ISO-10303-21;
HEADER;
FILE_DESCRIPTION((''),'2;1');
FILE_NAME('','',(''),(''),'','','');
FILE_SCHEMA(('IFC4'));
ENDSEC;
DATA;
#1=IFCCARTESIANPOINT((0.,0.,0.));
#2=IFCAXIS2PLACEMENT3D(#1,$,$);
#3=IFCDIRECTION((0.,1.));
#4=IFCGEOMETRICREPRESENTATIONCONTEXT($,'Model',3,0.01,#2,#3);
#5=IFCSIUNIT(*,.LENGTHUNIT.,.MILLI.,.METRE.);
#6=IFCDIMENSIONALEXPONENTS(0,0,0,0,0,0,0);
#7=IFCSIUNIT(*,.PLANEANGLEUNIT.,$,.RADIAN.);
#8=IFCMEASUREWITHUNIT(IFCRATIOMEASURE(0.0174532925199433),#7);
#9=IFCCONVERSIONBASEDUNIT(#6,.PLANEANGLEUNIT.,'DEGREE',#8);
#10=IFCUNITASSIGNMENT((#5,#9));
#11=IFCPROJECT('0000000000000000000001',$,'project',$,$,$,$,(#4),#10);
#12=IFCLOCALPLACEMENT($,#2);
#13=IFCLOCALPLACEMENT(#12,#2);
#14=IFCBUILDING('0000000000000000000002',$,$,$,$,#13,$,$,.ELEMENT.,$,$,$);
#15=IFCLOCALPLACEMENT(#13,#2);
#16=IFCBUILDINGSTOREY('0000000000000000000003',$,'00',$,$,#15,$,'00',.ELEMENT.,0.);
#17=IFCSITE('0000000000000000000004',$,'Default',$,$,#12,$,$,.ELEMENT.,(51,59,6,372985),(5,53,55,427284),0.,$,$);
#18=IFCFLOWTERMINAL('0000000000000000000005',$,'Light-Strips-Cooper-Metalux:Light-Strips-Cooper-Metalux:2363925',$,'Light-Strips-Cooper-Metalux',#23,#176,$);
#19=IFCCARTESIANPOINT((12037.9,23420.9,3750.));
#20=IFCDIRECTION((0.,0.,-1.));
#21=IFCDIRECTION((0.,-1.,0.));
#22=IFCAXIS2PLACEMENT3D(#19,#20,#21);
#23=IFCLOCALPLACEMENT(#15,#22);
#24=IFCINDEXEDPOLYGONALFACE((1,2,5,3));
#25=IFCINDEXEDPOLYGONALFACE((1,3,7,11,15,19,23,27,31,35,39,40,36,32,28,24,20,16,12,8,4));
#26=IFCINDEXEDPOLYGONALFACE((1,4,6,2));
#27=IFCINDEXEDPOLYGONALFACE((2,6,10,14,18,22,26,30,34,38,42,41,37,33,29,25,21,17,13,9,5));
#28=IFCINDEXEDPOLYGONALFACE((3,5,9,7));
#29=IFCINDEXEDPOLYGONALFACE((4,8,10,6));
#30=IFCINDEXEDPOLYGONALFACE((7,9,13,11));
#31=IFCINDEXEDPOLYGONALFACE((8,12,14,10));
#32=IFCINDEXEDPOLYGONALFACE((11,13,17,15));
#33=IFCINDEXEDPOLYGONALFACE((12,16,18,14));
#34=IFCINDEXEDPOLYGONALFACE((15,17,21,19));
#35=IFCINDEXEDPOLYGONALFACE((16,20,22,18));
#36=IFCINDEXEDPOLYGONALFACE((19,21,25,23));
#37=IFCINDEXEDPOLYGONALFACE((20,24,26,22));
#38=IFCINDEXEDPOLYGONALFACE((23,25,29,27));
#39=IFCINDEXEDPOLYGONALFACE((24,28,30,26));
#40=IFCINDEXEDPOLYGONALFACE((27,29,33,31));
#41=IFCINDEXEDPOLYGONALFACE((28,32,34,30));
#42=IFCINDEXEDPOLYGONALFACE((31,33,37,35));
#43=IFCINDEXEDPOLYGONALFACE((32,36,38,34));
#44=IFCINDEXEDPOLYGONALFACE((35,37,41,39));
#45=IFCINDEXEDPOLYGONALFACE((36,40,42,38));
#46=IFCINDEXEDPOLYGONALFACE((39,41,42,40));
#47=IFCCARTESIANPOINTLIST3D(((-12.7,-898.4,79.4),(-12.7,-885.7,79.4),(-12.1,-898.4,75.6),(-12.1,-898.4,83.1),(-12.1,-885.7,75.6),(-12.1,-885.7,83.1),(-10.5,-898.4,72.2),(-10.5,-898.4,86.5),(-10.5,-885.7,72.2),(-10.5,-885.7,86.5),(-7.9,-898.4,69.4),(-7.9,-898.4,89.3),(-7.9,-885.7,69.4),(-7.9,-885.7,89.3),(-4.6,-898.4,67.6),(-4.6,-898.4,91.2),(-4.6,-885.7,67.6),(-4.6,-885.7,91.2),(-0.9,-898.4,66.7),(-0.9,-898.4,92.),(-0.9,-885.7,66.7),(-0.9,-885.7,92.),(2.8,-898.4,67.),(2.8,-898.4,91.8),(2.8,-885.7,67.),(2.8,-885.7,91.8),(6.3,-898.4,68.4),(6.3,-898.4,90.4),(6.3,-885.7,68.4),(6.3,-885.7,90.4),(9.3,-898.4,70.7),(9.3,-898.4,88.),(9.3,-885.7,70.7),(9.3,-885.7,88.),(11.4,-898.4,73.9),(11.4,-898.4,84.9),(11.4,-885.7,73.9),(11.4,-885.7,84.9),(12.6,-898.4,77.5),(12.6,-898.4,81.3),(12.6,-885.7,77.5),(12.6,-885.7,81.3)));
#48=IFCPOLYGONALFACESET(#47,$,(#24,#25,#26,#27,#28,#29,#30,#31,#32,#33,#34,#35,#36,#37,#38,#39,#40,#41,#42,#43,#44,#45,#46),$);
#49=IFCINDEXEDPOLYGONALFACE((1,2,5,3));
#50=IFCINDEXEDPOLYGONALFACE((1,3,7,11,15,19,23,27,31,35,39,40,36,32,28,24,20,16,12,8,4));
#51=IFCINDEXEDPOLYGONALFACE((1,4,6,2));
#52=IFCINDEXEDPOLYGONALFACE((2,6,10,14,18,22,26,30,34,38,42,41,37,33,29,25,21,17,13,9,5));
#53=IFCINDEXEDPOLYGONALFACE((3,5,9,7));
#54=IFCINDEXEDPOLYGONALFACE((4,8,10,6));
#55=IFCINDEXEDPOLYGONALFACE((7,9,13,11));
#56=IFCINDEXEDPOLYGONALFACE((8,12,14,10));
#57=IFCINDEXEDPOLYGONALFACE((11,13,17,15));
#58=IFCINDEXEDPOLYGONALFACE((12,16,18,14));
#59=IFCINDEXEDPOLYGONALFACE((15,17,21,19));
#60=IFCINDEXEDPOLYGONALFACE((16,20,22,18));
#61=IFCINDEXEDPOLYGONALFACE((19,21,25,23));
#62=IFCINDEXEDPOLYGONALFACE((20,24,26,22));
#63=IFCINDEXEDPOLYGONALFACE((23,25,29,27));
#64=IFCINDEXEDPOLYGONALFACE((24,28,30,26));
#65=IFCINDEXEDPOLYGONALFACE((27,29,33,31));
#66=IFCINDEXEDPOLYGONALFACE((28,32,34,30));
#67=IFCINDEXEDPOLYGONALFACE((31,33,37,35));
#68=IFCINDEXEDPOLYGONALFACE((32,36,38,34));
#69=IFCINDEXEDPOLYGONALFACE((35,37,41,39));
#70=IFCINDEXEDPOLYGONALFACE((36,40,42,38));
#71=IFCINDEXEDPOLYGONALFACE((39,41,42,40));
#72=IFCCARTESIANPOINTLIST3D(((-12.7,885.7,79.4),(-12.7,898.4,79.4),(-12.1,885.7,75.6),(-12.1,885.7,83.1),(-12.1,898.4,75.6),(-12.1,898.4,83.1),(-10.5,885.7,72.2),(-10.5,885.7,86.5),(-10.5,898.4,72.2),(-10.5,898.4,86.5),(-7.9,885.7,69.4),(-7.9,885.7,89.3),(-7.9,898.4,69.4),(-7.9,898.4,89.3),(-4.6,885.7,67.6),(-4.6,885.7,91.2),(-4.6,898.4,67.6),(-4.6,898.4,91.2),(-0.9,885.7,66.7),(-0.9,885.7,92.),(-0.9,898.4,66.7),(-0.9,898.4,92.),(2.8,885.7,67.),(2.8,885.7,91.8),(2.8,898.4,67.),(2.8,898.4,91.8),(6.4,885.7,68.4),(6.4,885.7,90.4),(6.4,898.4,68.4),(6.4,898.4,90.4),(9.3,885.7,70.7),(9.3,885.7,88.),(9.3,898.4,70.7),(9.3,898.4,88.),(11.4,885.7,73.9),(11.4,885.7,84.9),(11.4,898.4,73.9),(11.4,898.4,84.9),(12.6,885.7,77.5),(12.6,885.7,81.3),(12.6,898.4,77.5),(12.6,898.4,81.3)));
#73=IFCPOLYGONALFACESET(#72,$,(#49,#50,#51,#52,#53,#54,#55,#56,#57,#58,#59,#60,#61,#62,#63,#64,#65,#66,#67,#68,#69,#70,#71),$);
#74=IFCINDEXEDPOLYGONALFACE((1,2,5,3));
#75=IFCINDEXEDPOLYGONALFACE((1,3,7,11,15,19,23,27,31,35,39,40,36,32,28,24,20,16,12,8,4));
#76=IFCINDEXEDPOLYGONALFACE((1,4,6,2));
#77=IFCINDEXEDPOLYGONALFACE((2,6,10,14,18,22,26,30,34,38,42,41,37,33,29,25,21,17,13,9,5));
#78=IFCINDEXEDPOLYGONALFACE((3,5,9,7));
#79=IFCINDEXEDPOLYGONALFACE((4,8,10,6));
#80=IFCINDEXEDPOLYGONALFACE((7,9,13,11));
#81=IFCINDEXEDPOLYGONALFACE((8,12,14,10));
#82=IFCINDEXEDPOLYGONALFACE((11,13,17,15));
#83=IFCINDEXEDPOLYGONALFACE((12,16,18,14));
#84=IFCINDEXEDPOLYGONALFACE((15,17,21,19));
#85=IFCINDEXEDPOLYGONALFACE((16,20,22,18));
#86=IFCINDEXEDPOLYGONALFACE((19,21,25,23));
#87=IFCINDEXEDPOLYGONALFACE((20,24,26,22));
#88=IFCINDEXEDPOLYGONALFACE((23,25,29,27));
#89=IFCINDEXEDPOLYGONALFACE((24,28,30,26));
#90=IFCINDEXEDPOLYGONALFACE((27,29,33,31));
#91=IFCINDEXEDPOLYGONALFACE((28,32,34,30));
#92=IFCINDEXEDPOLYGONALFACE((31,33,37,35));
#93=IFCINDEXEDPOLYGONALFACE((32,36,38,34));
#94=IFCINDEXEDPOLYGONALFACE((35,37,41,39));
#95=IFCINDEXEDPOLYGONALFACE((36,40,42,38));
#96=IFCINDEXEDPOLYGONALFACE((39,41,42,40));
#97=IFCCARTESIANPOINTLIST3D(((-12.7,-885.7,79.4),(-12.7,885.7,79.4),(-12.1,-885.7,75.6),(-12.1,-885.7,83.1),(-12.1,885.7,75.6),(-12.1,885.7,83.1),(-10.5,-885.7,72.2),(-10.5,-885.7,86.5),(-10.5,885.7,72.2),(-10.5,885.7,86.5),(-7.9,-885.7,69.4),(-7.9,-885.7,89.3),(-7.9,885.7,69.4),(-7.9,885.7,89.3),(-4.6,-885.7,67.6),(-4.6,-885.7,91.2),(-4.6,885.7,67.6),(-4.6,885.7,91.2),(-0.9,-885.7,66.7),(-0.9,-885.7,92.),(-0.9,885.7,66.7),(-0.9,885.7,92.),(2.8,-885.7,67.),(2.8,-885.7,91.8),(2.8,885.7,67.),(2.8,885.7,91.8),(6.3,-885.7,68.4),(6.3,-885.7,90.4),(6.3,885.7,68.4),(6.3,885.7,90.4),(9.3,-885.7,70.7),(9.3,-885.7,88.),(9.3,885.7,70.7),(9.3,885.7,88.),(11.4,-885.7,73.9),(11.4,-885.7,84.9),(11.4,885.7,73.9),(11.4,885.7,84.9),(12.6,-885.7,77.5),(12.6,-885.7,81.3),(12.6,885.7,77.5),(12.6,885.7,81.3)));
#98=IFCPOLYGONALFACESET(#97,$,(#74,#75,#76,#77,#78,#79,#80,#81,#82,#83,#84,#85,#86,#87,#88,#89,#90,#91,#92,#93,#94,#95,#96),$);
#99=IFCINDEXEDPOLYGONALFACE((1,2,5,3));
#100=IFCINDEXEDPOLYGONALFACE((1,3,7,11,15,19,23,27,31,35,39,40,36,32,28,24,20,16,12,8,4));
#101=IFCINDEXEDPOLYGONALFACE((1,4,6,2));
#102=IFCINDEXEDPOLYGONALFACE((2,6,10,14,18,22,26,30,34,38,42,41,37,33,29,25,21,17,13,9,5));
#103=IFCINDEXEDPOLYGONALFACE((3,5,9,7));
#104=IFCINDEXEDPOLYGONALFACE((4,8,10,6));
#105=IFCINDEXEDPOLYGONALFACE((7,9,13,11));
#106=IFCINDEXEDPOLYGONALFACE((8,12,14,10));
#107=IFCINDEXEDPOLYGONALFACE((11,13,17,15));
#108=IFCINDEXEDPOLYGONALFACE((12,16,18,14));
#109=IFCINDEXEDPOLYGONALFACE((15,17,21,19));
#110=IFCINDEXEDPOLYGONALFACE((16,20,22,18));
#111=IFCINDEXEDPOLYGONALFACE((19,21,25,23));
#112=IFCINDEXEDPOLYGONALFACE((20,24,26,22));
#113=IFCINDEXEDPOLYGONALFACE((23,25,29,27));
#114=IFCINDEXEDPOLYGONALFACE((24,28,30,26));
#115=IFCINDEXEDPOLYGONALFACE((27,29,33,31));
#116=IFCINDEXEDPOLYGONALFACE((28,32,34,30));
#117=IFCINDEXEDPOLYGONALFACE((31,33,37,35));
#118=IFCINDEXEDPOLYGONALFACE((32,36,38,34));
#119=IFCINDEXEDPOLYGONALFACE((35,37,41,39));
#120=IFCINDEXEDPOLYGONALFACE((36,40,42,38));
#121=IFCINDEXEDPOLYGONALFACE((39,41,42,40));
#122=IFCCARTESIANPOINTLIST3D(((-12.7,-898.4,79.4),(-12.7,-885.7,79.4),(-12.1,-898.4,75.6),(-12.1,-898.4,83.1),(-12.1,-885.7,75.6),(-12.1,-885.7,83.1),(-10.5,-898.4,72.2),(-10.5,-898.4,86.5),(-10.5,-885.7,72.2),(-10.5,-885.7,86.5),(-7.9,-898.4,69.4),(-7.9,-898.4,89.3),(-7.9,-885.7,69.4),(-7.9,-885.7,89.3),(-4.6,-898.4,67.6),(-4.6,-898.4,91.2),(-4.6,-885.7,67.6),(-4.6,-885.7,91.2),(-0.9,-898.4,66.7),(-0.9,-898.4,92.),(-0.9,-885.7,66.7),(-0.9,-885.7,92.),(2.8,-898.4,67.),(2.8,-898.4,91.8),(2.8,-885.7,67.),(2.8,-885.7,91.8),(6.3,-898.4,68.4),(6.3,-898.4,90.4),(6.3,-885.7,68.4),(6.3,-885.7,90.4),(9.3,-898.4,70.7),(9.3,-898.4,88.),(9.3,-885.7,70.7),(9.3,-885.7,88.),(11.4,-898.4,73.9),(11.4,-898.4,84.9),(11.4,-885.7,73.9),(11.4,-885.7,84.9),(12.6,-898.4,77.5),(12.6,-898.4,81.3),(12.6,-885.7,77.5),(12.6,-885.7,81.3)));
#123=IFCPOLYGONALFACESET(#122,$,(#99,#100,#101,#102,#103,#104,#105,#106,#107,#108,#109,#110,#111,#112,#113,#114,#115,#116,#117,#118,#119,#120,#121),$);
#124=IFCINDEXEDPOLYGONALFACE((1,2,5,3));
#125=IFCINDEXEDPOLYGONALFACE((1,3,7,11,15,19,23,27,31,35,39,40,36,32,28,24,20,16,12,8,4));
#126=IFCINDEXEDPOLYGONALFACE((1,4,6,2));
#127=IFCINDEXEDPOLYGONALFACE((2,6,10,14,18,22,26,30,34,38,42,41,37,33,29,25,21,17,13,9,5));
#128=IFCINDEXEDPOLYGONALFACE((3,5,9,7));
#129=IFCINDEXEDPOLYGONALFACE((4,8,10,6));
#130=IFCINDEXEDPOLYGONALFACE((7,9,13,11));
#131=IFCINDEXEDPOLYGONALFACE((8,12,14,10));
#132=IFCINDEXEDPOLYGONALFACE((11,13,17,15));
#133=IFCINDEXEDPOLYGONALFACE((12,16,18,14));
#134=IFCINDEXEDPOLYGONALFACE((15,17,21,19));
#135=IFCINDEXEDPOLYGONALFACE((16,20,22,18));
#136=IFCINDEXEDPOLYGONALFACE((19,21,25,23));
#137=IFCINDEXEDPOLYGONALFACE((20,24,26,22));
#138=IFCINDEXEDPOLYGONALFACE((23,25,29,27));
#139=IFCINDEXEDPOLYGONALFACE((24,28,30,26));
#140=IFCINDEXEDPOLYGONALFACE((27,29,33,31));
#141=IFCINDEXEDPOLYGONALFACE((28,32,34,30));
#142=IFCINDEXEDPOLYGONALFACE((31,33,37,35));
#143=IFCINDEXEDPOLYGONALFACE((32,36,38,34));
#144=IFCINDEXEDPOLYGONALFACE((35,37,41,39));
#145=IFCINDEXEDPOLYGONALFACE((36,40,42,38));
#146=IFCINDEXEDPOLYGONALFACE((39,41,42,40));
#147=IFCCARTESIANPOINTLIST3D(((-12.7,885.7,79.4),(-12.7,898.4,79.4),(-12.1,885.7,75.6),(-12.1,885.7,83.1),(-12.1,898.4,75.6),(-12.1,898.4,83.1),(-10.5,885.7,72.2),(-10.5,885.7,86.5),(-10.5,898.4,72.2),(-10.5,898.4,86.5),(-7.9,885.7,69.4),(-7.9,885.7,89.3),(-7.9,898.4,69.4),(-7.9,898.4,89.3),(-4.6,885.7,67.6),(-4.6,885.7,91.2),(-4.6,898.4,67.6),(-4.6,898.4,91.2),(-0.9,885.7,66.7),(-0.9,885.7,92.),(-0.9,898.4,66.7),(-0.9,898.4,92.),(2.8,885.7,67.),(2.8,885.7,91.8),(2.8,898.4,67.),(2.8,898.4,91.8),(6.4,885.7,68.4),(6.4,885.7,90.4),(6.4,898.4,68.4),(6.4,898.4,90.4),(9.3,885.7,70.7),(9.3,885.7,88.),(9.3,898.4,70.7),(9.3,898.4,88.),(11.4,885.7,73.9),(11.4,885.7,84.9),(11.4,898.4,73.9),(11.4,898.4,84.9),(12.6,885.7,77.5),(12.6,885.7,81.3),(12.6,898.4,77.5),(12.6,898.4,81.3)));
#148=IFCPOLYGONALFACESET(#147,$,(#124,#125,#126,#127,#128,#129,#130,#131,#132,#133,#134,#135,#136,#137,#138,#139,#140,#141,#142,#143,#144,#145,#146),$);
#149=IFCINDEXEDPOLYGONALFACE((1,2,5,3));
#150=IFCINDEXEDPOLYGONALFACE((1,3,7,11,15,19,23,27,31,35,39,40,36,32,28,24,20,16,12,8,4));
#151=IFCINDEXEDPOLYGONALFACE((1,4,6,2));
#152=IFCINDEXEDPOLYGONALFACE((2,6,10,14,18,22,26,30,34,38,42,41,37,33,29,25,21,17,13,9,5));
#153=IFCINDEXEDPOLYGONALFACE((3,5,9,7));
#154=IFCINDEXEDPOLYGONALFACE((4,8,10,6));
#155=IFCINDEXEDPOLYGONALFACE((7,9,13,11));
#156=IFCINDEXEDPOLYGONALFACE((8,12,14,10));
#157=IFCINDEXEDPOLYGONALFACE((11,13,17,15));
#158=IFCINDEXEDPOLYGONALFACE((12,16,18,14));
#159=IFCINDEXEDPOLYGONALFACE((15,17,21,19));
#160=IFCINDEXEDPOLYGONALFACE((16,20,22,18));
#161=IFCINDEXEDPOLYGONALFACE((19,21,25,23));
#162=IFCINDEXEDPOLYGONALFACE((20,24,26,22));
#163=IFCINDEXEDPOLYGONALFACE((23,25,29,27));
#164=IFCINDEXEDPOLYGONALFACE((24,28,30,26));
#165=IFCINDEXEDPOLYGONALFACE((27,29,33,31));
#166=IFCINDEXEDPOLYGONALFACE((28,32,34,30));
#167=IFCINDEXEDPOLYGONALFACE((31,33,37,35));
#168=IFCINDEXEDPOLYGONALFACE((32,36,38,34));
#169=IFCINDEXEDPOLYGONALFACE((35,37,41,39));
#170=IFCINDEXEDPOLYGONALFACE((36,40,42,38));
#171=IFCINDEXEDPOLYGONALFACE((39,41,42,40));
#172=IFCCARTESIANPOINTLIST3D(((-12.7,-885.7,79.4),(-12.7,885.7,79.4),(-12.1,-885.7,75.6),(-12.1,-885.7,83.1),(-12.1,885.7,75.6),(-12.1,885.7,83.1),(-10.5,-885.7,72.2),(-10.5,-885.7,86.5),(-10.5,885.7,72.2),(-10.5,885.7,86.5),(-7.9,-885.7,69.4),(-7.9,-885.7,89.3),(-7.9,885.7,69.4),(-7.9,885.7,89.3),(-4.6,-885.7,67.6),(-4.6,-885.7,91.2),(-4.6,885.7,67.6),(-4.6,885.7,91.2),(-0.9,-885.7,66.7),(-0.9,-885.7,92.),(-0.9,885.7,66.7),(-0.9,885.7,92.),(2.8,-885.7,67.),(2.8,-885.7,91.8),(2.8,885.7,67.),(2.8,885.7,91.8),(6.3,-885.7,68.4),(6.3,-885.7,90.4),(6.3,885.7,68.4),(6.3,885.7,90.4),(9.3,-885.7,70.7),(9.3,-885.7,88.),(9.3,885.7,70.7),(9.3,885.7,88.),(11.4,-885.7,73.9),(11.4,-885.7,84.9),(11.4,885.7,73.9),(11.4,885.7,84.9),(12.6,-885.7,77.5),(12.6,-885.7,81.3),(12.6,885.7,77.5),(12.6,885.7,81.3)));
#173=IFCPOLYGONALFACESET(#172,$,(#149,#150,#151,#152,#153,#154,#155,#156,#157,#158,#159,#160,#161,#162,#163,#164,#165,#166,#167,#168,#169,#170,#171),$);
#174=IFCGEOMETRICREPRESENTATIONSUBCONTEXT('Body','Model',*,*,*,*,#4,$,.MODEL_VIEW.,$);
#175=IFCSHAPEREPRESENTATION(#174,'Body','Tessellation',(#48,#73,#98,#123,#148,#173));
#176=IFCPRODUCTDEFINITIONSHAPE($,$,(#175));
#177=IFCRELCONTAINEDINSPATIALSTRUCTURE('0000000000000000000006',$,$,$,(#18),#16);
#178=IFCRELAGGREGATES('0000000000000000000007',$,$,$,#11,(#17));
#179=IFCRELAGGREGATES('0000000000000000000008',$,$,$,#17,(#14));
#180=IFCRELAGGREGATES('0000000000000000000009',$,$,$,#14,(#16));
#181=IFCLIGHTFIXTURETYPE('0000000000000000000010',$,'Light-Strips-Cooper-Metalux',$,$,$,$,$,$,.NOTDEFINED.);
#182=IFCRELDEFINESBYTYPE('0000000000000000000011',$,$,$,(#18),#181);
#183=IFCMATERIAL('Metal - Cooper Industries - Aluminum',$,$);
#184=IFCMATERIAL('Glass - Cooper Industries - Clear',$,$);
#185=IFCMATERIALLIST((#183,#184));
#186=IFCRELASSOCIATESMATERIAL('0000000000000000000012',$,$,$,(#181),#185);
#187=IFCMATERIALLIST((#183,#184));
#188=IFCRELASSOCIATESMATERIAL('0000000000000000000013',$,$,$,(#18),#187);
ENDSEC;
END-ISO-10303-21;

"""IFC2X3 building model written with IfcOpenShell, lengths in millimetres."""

from ifc_helpers import new_model, entity, si_unit, converted_unit, direction, frame, frame_2d, origin, place, context, subcontext, project, spatial, circle, extrude, source, transform, mapped, material, material_list, type_object, type_shapes, element, save


model = new_model("IFC2X3")

# Units and contexts
model_context = context("Model", 3, precision=0.01, world=origin(), true_north=direction((0.0, 1.0)))
body_context = subcontext(model_context, "Body", "Model", "MODEL_VIEW")
ifc_project = project(units=[si_unit("LENGTHUNIT", "METRE", prefix="MILLI"), converted_unit("PLANEANGLEUNIT", "DEGREE", entity("IfcRatioMeasure", 0.0174532925199433), si_unit("PLANEANGLEUNIT", "RADIAN"), dimensions=[0, 0, 0, 0, 0, 0, 0])], contexts=[model_context])

# Site, building, storey
site_placement = place(None, origin())
site = spatial("IfcSite", under=ifc_project, at=site_placement, Name="Default", CompositionType="ELEMENT", RefLatitude=(51, 59, 6, 372985), RefLongitude=(5, 53, 55, 427284), RefElevation=0.0)
building_placement = place(site_placement, origin())
building = spatial("IfcBuilding", under=site, at=building_placement, CompositionType="ELEMENT")
storey_placement = place(building_placement, origin())
storey = spatial("IfcBuildingStorey", under=building, at=storey_placement, Name="00", LongName="00", CompositionType="ELEMENT", Elevation=0.0)

# Flow terminal
ifc_material_1 = material(Name="Metal - Cooper Industries - Aluminum")
ifc_material_2 = material(Name="Glass - Cooper Industries - Clear")
ifc_material_list_1 = material_list([ifc_material_1, ifc_material_2])
ifc_material_list_2 = material_list([ifc_material_1, ifc_material_2])
light_fixture_type = type_object("IfcLightFixtureType", Name="Light-Strips-Cooper-Metalux", PredefinedType="NOTDEFINED", material=ifc_material_list_2)
shared_shape_1 = source(origin(), body_context, "Body", "SweptSolid", [
    extrude(circle(Radius=12.7, at=frame_2d((0.0, 0.0), x_axis=(1.0, 0.0))), frame((0.0, -898.4, 79.4), z_axis=(0.0, 1.0, 0.0), x_axis=(-1.0, 0.0, 0.0)), (0.0, 0.0, 1.0), 12.7),
    extrude(circle(Radius=12.7, at=frame_2d((0.0, 0.0), x_axis=(1.0, 0.0))), frame((0.0, 885.7, 79.4), z_axis=(0.0, 1.0, 0.0), x_axis=(-1.0, 0.0, 0.0)), (0.0, 0.0, 1.0), 12.7),
    extrude(circle(Radius=12.7, at=frame_2d((0.0, 0.0), x_axis=(1.0, 0.0))), frame((0.0, -885.7, 79.4), z_axis=(0.0, 1.0, 0.0), x_axis=(-1.0, 0.0, 0.0)), (0.0, 0.0, 1.0), 1771.4),
    extrude(circle(Radius=12.7, at=frame_2d((0.0, 0.0), x_axis=(1.0, 0.0))), frame((0.0, -898.4, 79.4), z_axis=(0.0, 1.0, 0.0), x_axis=(-1.0, 0.0, 0.0)), (0.0, 0.0, 1.0), 12.7),
    extrude(circle(Radius=12.7, at=frame_2d((0.0, 0.0), x_axis=(1.0, 0.0))), frame((0.0, 885.7, 79.4), z_axis=(0.0, 1.0, 0.0), x_axis=(-1.0, 0.0, 0.0)), (0.0, 0.0, 1.0), 12.7),
    extrude(circle(Radius=12.7, at=frame_2d((0.0, 0.0), x_axis=(1.0, 0.0))), frame((0.0, -885.7, 79.4), z_axis=(0.0, 1.0, 0.0), x_axis=(-1.0, 0.0, 0.0)), (0.0, 0.0, 1.0), 1771.4),
])
type_shapes(light_fixture_type, [shared_shape_1])
flow_terminal_placement = place(storey_placement, frame((12037.9, 23420.9, 3750.0), z_axis=(0.0, 0.0, -1.0), x_axis=(0.0, -1.0, 0.0)))
element("IfcFlowTerminal", 1, at=flow_terminal_placement, inside=storey, type_object=light_fixture_type, material=ifc_material_list_1, Name="Light-Strips-Cooper-Metalux:Light-Strips-Cooper-Metalux:2363925", ObjectType="Light-Strips-Cooper-Metalux", context=body_context, shape_type="MappedRepresentation", body=[
    mapped(shared_shape_1, transform((0.0, 0.0, 0.0), scale=1.0)),
])

save(model, "model.ifc")
